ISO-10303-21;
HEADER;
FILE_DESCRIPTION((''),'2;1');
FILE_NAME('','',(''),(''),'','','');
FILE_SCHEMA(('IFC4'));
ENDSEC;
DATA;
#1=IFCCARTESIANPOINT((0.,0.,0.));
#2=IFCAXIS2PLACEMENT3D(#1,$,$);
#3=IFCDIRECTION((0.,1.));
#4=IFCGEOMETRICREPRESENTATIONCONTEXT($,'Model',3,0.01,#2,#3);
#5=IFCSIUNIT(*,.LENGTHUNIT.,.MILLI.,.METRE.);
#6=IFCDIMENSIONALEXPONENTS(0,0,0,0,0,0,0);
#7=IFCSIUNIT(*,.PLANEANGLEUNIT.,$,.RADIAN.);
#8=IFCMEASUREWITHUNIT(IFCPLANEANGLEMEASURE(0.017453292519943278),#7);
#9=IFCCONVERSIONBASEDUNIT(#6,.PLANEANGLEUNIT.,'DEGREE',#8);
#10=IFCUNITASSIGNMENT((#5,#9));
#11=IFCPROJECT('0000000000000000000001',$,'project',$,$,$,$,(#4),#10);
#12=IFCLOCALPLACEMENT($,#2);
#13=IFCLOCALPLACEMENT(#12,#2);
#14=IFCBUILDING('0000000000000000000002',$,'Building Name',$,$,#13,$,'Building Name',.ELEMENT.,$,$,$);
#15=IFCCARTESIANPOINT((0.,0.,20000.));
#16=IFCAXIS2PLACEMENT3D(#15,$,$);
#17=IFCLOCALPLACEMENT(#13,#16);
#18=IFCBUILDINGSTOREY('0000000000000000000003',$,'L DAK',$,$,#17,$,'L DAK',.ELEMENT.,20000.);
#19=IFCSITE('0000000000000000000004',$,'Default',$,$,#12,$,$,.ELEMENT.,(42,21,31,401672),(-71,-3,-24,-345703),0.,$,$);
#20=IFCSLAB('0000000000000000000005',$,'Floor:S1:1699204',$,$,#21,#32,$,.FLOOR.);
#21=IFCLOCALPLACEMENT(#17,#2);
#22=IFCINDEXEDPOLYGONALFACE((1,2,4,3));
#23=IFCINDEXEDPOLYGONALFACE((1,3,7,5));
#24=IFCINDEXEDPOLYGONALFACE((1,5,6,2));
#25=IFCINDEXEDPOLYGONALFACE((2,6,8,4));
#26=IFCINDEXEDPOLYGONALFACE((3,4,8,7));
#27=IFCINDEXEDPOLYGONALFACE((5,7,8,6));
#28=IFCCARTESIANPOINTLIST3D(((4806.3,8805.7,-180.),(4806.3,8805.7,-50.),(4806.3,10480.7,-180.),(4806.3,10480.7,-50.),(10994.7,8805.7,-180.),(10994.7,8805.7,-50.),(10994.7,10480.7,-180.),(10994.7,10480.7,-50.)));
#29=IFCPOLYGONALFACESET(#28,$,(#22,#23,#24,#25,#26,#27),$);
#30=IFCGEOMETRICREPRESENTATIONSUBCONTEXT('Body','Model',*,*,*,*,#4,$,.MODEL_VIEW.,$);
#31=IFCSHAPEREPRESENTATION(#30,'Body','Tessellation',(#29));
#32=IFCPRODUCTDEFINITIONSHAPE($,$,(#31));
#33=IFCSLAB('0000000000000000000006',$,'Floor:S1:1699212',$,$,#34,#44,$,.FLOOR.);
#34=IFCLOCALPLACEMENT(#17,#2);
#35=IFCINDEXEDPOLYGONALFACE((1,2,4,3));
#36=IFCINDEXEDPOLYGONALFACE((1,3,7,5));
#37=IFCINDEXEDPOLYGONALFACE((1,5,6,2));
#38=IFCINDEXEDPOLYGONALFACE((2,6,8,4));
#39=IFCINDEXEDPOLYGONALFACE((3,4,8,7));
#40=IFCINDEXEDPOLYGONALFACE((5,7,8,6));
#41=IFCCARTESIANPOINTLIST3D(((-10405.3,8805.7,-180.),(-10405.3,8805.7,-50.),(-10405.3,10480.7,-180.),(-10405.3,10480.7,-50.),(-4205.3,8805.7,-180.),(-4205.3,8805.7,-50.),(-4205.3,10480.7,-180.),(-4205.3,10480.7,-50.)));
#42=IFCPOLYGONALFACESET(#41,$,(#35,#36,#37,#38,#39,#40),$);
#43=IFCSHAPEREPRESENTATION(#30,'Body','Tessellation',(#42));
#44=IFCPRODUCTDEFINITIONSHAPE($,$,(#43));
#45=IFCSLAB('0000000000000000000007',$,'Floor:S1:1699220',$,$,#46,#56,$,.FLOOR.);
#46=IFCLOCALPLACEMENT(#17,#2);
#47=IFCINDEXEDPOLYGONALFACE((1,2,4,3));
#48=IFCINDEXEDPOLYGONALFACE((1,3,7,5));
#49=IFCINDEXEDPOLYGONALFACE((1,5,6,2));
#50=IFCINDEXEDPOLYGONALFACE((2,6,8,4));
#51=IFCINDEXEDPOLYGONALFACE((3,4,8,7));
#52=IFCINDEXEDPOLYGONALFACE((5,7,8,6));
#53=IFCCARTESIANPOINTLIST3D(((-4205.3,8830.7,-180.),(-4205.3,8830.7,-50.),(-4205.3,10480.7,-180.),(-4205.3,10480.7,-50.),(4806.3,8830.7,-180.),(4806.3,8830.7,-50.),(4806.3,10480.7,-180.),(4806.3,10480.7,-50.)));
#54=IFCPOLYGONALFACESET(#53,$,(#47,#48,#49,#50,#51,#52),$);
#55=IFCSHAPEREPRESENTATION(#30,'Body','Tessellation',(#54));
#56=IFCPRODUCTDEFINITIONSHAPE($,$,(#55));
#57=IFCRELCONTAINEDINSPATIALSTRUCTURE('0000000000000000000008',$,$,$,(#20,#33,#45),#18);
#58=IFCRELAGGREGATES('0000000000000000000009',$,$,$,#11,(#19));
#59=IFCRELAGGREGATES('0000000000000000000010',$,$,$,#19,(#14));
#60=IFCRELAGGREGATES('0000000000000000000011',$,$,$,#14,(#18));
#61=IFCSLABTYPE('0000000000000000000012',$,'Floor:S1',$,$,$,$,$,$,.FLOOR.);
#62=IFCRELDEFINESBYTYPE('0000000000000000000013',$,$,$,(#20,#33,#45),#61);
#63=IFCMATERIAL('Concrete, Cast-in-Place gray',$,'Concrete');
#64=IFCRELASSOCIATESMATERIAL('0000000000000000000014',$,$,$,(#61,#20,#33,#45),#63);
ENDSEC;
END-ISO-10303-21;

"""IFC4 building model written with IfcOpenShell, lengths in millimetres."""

from ifc_helpers import new_model, entity, si_unit, converted_unit, direction, frame, origin, place, context, subcontext, project, spatial, indexed_curve, outline, extrude, material, type_object, element, save


model = new_model("IFC4")

# Units and contexts
model_context = context("Model", 3, precision=0.01, world=origin(), true_north=direction((0.0, 1.0)))
body_context = subcontext(model_context, "Body", "Model", "MODEL_VIEW")
ifc_project = project(units=[si_unit("LENGTHUNIT", "METRE", prefix="MILLI"), converted_unit("PLANEANGLEUNIT", "DEGREE", entity("IfcPlaneAngleMeasure", 0.017453292519943278), si_unit("PLANEANGLEUNIT", "RADIAN"), dimensions=[0, 0, 0, 0, 0, 0, 0])], contexts=[model_context])

# Site, building, storey
site_placement = place(None, origin())
site = spatial("IfcSite", under=ifc_project, at=site_placement, Name="Default", CompositionType="ELEMENT", RefLatitude=(42, 21, 31, 401672), RefLongitude=(-71, -3, -24, -345703), RefElevation=0.0)
building_placement = place(site_placement, origin())
building = spatial("IfcBuilding", under=site, at=building_placement, Name="Building Name", LongName="Building Name", CompositionType="ELEMENT")
storey_placement = place(building_placement, frame((0.0, 0.0, 20000.0)))
storey = spatial("IfcBuildingStorey", under=building, at=storey_placement, Name="L DAK", LongName="L DAK", CompositionType="ELEMENT", Elevation=20000.0)

# Slabs
ifc_material = material(Name="Concrete, Cast-in-Place gray", Category="Concrete")
slab_type = type_object("IfcSlabType", Name="Floor:S1", PredefinedType="FLOOR", material=ifc_material)
slab_1_placement = place(storey_placement, origin())
element("IfcSlab", 1, at=slab_1_placement, inside=storey, type_object=slab_type, material=ifc_material, Name="Floor:S1:1699204", PredefinedType="FLOOR", context=body_context, shape_type="SweptSolid", body=[
    extrude(outline(indexed_curve([(-837.5, -3094.2), (837.5, -3094.2), (837.5, 3094.2), (-837.5, 3094.2), (-837.5, -3094.2)], self_intersect=False)), frame((7900.5, 9643.2, -50.0), z_axis=(0.0, 0.0, -1.0), x_axis=(0.0, 1.0, 0.0)), (0.0, 0.0, 1.0), 130.0),
])
slab_2_placement = place(storey_placement, origin())
element("IfcSlab", 2, at=slab_2_placement, inside=storey, type_object=slab_type, material=ifc_material, Name="Floor:S1:1699212", PredefinedType="FLOOR", context=body_context, shape_type="SweptSolid", body=[
    extrude(outline(indexed_curve([(-837.5, -3100.0), (837.5, -3100.0), (837.5, 3100.0), (-837.5, 3100.0), (-837.5, -3100.0)], self_intersect=False)), frame((-7305.3, 9643.2, -50.0), z_axis=(0.0, 0.0, -1.0), x_axis=(0.0, 1.0, 0.0)), (0.0, 0.0, 1.0), 130.0),
])
slab_3_placement = place(storey_placement, origin())
element("IfcSlab", 3, at=slab_3_placement, inside=storey, type_object=slab_type, material=ifc_material, Name="Floor:S1:1699220", PredefinedType="FLOOR", context=body_context, shape_type="SweptSolid", body=[
    extrude(outline(indexed_curve([(-825.0, -4505.8), (825.0, -4505.8), (825.0, 4505.8), (-825.0, 4505.8), (-825.0, -4505.8)], self_intersect=False)), frame((300.5, 9655.7, -50.0), z_axis=(0.0, 0.0, -1.0), x_axis=(0.0, 1.0, 0.0)), (0.0, 0.0, 1.0), 130.0),
])

save(model, "model.ifc")
